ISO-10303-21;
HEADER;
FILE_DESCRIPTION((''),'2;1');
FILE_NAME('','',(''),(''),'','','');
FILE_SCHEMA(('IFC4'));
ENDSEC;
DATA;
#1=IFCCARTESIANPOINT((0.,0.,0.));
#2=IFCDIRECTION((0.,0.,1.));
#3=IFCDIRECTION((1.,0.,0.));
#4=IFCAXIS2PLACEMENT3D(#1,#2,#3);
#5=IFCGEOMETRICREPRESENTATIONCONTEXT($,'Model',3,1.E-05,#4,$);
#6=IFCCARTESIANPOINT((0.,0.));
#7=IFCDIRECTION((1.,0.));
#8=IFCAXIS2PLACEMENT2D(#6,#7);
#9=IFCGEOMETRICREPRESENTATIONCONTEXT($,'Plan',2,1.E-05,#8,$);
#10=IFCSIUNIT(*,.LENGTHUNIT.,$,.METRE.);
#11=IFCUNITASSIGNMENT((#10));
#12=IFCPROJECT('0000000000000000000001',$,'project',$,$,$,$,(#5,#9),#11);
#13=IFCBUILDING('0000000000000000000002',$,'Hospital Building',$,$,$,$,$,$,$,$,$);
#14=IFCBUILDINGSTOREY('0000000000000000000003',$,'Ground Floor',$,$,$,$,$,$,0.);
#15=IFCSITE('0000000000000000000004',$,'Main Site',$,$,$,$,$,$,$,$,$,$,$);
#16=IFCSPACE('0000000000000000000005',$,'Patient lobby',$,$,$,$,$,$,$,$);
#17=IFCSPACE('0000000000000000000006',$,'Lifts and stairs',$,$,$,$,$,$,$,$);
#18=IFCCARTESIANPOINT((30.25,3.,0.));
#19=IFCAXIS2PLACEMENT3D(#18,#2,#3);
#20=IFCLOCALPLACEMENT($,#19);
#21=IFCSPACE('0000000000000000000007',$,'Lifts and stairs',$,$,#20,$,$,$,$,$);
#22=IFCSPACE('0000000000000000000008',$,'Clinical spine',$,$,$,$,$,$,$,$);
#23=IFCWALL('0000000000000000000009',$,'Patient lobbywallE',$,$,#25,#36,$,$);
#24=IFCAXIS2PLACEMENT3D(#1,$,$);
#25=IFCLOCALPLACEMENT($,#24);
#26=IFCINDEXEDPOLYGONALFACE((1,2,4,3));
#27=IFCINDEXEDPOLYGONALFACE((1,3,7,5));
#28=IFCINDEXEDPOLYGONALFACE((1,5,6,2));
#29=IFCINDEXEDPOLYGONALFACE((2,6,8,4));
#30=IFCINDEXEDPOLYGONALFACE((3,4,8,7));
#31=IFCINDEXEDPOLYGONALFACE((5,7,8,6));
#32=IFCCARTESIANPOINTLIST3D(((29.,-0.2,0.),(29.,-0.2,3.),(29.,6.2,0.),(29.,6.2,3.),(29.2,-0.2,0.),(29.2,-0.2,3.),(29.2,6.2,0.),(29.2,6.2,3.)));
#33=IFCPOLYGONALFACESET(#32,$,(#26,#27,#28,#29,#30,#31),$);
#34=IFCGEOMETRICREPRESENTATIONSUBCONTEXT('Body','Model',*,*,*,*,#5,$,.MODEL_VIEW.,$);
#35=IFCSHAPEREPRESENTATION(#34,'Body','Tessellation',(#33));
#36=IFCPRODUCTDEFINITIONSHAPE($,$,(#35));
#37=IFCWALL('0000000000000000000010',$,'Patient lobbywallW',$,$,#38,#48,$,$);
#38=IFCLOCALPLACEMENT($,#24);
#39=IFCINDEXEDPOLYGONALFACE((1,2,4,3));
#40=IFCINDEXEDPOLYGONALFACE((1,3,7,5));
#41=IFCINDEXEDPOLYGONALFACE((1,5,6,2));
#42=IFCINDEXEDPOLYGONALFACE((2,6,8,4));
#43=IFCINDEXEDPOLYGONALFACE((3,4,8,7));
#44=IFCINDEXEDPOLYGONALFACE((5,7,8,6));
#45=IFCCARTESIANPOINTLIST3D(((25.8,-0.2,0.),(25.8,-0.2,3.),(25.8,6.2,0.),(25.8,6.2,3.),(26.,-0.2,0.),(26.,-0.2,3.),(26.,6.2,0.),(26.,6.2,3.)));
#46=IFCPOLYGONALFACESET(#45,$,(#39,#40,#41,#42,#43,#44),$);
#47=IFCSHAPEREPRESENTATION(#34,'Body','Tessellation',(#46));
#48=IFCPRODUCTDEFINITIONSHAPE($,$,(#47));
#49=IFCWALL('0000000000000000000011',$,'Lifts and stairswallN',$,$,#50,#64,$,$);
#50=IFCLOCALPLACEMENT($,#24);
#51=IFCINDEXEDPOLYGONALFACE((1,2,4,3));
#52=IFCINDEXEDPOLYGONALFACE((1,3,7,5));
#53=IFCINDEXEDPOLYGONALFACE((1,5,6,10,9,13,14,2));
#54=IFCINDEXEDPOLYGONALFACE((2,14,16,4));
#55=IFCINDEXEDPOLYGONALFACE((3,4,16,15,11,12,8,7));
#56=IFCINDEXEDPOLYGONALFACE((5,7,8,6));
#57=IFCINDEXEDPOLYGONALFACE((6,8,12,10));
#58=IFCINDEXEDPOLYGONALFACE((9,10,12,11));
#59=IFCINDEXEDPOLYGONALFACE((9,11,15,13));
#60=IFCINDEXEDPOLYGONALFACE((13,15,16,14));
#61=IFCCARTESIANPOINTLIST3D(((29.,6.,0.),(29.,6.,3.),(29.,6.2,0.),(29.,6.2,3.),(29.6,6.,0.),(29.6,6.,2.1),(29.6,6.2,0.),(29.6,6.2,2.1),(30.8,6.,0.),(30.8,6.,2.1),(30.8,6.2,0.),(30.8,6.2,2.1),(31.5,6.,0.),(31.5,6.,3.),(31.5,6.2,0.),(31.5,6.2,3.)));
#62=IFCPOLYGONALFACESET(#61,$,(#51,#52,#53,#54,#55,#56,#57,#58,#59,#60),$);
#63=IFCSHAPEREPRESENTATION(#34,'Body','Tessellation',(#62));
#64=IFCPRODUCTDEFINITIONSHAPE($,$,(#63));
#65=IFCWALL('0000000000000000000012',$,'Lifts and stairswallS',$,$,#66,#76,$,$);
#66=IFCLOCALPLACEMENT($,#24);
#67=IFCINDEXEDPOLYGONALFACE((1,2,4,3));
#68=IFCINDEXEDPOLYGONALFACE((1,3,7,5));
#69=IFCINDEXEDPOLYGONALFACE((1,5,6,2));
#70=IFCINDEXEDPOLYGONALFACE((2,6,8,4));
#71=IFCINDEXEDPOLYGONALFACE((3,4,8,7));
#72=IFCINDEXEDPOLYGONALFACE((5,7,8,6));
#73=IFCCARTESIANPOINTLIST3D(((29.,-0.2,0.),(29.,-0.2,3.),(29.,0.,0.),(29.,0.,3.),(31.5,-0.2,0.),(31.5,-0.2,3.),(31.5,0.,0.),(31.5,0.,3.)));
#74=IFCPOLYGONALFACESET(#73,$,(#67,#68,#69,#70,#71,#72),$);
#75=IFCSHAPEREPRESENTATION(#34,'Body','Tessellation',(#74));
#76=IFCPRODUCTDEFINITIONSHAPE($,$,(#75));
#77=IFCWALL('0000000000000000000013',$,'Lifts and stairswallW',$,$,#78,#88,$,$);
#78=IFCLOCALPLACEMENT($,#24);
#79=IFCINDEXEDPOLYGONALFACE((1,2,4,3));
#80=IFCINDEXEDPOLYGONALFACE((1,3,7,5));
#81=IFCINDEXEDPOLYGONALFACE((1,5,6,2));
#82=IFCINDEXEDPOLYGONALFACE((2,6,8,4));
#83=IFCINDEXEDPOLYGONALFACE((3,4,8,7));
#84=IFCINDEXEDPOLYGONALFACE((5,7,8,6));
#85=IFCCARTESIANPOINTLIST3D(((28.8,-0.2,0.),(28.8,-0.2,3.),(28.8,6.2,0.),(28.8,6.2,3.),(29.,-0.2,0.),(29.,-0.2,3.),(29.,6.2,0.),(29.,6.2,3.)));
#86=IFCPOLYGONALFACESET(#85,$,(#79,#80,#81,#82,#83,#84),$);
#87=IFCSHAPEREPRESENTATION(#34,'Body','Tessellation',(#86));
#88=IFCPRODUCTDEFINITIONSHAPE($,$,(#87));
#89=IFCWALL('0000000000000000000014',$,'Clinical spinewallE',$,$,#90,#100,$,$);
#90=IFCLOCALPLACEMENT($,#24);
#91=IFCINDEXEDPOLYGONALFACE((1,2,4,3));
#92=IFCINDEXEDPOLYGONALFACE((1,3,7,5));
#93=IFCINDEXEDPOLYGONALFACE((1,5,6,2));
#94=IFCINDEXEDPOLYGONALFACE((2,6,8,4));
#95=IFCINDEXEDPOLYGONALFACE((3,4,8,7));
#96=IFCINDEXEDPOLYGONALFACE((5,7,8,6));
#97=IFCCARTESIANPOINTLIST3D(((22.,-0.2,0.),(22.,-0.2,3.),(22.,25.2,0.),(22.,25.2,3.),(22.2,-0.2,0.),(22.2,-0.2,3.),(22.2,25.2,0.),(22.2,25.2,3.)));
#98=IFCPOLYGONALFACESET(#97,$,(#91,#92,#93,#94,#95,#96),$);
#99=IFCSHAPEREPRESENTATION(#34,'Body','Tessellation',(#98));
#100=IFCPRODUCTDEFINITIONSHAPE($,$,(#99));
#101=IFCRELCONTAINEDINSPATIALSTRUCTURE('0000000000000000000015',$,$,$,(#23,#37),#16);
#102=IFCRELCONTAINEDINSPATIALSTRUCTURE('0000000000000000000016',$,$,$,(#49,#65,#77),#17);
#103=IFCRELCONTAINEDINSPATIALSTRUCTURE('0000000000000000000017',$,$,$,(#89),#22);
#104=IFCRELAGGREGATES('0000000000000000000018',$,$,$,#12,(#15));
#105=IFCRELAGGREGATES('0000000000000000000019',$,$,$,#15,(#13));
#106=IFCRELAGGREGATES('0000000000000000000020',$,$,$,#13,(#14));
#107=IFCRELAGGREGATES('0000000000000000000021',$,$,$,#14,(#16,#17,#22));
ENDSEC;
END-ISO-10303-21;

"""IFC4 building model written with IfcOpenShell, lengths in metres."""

from ifc_helpers import new_model, si_unit, frame, origin_with_axes, origin_2d_with_axis, place, context, subcontext, project, spatial, indexed_curve, outline, extrude, element, save


model = new_model("IFC4")

# Units and contexts
model_context = context("Model", 3, precision=1e-05, world=origin_with_axes())
plan_context = context("Plan", 2, precision=1e-05, world=origin_2d_with_axis())
body_context = subcontext(model_context, "Body", "Model", "MODEL_VIEW")
ifc_project = project(units=[si_unit("LENGTHUNIT", "METRE")], contexts=[model_context, plan_context])

# Site, building, storey
site = spatial("IfcSite", under=ifc_project, Name="Main Site")
building = spatial("IfcBuilding", under=site, Name="Hospital Building")
storey = spatial("IfcBuildingStorey", under=building, Name="Ground Floor", Elevation=0.0)

# Shared definitions
space_1 = spatial("IfcSpace", under=storey, Name="Patient lobby")

# Shared definitions
space_2 = spatial("IfcSpace", under=storey, Name="Lifts and stairs")

# Walls
for number, where, z_axis, x_axis, name in (
    (1, (29.2, -0.2, 0.0), (0.0, 0.0, 1.0), (0.0, 1.0, 0.0), "Patient lobbywallE"),
    (2, (26.0, -0.2, 0.0), (0.0, 0.0, 1.0), (0.0, 1.0, 0.0), "Patient lobbywallW"),
):
    element("IfcWall", number, at=place(None, frame(where, z_axis=z_axis, x_axis=x_axis)), inside=space_1, Name=name, context=body_context, shape_type="SweptSolid", body=[
        extrude(outline(indexed_curve([(0.0, 0.0), (0.0, 0.2), (6.4, 0.2), (6.4, 0.0), (0.0, 0.0)], self_intersect=False)), origin_with_axes(), (0.0, 0.0, 1.0), 3.0),
    ])

# Wall
wall_1_placement = place(None, frame((29.0, 6.0, 0.0), z_axis=(0.0, 0.0, 1.0), x_axis=(1.0, 0.0, 0.0)))
wall_1 = element("IfcWall", 3, at=wall_1_placement, inside=space_2, Name="Lifts and stairswallN", context=body_context, shape_type="SweptSolid", body=[
    extrude(outline(indexed_curve([(0.0, 0.0), (0.0, 0.2), (2.5, 0.2), (2.5, 0.0), (0.0, 0.0)], self_intersect=False)), origin_with_axes(), (0.0, 0.0, 1.0), 3.0),
])

# Shared definitions
space_3_placement = place(None, frame((30.25, 3.0, 0.0), z_axis=(0.0, 0.0, 1.0), x_axis=(1.0, 0.0, 0.0)))
space_3 = spatial("IfcSpace", at=space_3_placement, Name="Lifts and stairs")

# Opening
opening_1_placement = place(wall_1_placement, frame((0.6, -0.1, 0.0), z_axis=(0.0, 0.0, 1.0), x_axis=(1.0, 0.0, 0.0)))
element("IfcOpeningElement", 4, at=opening_1_placement, inside=space_3, cuts=wall_1, context=body_context, shape_type="SweptSolid", body=[
    extrude(outline(indexed_curve([(0.0, 0.0), (0.0, 0.4), (1.2, 0.4), (1.2, 0.0), (0.0, 0.0)], self_intersect=False)), origin_with_axes(), (0.0, 0.0, 1.0), 2.1),
])

# Walls
wall_2_placement = place(None, frame((29.0, -0.2, 0.0), z_axis=(0.0, 0.0, 1.0), x_axis=(1.0, 0.0, 0.0)))
element("IfcWall", 5, at=wall_2_placement, inside=space_2, Name="Lifts and stairswallS", context=body_context, shape_type="SweptSolid", body=[
    extrude(outline(indexed_curve([(0.0, 0.0), (0.0, 0.2), (2.5, 0.2), (2.5, 0.0), (0.0, 0.0)], self_intersect=False)), origin_with_axes(), (0.0, 0.0, 1.0), 3.0),
])
wall_3_placement = place(None, frame((29.0, -0.2, 0.0), z_axis=(0.0, 0.0, 1.0), x_axis=(0.0, 1.0, 0.0)))
element("IfcWall", 6, at=wall_3_placement, inside=space_2, Name="Lifts and stairswallW", context=body_context, shape_type="SweptSolid", body=[
    extrude(outline(indexed_curve([(0.0, 0.0), (0.0, 0.2), (6.4, 0.2), (6.4, 0.0), (0.0, 0.0)], self_intersect=False)), origin_with_axes(), (0.0, 0.0, 1.0), 3.0),
])

# Shared definitions
space_4 = spatial("IfcSpace", under=storey, Name="Clinical spine")

# Wall
wall_4_placement = place(None, frame((22.2, -0.2, 0.0), z_axis=(0.0, 0.0, 1.0), x_axis=(0.0, 1.0, 0.0)))
element("IfcWall", 7, at=wall_4_placement, inside=space_4, Name="Clinical spinewallE", context=body_context, shape_type="SweptSolid", body=[
    extrude(outline(indexed_curve([(0.0, 0.0), (0.0, 0.2), (25.4, 0.2), (25.4, 0.0), (0.0, 0.0)], self_intersect=False)), origin_with_axes(), (0.0, 0.0, 1.0), 3.0),
])

save(model, "model.ifc")
